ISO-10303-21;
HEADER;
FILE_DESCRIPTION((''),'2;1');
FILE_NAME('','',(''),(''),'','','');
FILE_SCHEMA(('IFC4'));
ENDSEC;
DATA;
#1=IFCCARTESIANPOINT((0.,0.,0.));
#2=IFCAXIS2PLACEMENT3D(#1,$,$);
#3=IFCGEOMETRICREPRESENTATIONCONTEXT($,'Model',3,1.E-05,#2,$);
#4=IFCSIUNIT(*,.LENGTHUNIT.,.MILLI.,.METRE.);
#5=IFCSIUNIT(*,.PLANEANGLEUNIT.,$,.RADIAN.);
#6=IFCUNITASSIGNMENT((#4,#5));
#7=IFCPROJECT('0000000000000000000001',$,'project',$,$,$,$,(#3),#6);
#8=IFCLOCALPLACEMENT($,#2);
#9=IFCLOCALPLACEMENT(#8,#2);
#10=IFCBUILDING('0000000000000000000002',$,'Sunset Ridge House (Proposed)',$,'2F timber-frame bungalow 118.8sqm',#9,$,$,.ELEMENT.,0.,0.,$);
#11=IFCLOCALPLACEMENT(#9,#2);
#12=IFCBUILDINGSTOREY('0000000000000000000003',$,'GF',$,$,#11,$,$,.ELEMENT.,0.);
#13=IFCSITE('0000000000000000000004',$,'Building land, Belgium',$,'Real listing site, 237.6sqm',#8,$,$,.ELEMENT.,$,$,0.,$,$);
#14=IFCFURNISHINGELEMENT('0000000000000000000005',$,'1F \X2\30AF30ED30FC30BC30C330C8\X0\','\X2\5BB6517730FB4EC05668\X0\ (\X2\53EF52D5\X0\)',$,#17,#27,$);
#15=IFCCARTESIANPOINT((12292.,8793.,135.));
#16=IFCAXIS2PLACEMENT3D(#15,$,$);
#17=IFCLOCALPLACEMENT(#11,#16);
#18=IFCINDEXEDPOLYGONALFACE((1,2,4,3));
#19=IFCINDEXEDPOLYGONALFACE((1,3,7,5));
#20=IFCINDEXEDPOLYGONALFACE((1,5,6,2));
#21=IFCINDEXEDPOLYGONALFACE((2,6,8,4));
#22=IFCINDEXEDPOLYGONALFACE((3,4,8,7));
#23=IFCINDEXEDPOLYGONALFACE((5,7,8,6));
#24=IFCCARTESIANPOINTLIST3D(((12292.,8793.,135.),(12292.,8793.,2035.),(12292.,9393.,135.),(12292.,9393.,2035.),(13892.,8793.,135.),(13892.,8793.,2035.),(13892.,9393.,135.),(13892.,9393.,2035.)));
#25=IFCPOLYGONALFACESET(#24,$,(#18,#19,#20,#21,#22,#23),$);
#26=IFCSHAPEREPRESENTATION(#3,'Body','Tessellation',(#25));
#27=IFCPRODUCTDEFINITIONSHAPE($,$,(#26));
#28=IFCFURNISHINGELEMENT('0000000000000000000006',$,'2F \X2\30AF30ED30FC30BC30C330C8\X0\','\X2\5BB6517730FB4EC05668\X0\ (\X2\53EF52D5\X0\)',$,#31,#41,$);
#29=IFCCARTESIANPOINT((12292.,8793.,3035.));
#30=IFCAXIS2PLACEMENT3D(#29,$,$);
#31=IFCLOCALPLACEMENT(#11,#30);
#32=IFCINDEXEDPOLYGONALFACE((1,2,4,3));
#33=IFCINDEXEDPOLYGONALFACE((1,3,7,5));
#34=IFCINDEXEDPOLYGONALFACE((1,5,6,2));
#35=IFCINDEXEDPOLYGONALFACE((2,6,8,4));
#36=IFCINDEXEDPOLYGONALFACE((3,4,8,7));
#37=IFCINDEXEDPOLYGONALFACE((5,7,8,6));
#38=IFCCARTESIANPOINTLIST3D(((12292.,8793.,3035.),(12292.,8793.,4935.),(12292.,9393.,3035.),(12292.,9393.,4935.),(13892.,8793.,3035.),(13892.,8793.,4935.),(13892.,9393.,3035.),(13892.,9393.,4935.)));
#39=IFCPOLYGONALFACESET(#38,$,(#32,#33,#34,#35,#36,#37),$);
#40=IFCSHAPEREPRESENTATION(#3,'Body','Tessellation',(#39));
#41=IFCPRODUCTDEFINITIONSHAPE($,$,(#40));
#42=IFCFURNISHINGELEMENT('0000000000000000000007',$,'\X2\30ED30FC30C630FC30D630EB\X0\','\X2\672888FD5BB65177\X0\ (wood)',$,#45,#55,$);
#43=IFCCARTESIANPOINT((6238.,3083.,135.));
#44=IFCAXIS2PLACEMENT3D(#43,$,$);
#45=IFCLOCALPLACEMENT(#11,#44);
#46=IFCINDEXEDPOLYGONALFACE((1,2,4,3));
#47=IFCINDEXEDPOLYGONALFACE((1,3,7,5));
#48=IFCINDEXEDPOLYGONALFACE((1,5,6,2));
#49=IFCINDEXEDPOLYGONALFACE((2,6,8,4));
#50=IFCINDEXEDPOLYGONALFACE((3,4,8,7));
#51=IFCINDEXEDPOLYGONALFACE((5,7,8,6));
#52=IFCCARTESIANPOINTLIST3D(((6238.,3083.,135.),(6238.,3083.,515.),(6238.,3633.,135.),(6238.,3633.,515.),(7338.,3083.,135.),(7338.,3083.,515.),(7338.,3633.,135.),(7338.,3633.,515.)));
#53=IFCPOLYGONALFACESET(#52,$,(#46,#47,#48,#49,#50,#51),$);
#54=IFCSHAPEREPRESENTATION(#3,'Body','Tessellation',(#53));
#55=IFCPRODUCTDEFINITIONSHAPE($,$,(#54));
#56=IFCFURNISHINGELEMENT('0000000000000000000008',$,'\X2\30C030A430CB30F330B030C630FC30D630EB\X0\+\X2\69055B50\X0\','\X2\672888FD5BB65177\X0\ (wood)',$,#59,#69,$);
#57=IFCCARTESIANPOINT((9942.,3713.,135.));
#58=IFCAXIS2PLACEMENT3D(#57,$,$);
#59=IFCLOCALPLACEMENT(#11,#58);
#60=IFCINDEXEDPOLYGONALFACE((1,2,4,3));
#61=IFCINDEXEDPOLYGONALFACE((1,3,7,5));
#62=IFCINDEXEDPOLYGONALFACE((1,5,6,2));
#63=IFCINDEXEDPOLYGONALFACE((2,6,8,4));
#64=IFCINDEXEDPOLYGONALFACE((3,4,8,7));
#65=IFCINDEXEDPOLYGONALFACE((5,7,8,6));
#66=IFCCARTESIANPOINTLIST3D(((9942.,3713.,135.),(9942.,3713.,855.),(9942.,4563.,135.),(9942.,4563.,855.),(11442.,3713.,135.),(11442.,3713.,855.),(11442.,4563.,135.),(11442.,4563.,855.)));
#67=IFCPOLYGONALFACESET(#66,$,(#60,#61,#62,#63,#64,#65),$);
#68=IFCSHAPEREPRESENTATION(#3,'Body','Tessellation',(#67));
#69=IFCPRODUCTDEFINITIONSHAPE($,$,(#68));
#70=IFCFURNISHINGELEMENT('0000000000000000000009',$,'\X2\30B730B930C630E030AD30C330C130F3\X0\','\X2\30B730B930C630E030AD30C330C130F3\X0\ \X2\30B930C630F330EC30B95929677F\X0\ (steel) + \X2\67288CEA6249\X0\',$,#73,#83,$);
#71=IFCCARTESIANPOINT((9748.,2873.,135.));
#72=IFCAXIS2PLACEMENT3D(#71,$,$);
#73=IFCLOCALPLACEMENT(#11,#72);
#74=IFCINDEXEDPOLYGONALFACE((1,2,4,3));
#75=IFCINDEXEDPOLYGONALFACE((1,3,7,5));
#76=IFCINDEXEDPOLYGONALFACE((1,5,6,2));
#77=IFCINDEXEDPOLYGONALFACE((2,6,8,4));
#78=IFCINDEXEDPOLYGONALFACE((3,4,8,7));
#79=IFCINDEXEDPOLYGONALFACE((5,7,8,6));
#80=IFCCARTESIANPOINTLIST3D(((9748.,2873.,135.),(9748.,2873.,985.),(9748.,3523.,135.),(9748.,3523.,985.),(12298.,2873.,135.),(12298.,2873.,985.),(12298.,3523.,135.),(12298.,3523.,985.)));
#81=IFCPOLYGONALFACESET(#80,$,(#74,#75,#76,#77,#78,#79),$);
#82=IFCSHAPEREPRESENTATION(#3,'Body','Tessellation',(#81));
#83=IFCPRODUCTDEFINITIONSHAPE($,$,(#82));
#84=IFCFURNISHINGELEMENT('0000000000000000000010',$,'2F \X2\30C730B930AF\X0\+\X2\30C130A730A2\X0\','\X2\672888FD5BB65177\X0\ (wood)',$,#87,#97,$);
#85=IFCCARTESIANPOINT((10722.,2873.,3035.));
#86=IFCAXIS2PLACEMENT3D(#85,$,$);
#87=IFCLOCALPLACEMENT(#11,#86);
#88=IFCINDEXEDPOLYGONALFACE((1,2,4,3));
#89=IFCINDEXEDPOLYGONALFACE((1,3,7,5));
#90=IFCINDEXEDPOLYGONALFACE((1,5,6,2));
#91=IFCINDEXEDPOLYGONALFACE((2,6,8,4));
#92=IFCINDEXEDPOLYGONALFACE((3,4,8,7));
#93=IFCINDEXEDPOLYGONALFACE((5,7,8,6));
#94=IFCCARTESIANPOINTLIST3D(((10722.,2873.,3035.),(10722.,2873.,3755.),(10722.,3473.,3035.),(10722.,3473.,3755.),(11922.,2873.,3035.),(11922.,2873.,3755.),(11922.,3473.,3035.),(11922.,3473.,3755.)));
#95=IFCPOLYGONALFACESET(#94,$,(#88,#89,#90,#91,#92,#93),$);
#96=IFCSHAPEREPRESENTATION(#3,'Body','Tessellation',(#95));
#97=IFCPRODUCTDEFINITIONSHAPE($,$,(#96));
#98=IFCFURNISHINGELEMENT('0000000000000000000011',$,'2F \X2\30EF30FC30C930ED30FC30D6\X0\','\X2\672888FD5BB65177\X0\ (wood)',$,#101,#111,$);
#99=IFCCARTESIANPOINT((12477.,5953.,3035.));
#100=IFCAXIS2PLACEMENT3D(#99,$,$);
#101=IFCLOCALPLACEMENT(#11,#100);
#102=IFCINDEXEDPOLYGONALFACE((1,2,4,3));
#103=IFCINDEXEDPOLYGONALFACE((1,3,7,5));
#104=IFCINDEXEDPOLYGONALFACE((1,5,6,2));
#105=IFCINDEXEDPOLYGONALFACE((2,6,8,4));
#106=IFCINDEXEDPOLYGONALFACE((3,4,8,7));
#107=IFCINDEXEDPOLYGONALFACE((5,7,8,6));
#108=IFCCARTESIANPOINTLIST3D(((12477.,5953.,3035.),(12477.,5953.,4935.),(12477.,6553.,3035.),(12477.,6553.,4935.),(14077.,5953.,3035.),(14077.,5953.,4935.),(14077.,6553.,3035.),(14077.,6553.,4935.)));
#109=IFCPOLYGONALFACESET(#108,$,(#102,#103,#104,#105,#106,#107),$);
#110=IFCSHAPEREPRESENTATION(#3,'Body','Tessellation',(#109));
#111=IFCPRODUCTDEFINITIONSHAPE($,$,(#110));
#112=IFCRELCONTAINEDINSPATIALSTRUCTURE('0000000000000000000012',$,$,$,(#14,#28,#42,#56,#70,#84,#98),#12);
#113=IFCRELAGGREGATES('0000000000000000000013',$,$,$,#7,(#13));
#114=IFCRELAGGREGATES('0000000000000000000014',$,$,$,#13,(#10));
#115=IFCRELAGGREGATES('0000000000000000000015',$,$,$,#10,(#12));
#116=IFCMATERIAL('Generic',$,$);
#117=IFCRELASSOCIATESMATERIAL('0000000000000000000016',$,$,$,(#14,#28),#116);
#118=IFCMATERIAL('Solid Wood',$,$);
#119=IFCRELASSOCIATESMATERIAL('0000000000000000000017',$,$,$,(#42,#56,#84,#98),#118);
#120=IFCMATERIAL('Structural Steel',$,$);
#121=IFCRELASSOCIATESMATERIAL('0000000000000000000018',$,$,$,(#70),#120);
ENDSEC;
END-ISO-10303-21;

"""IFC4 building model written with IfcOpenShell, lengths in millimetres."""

from ifc_helpers import new_model, si_unit, frame, frame_2d, origin, place, context, project, spatial, rectangle, extrude, material, element, save


model = new_model("IFC4")

# Units and contexts
model_context = context("Model", 3, precision=1e-05, world=origin())
ifc_project = project(units=[si_unit("LENGTHUNIT", "METRE", prefix="MILLI"), si_unit("PLANEANGLEUNIT", "RADIAN")], contexts=[model_context])

# Site, building, storey
site_placement = place(None, origin())
site = spatial("IfcSite", under=ifc_project, at=site_placement, Name="Building land, Belgium", ObjectType="Real listing site, 237.6sqm", CompositionType="ELEMENT", RefElevation=0.0)
building_placement = place(site_placement, origin())
building = spatial("IfcBuilding", under=site, at=building_placement, Name="Sunset Ridge House (Proposed)", ObjectType="2F timber-frame bungalow 118.8sqm", CompositionType="ELEMENT", ElevationOfRefHeight=0.0, ElevationOfTerrain=0.0)
storey_placement = place(building_placement, origin())
storey = spatial("IfcBuildingStorey", under=building, at=storey_placement, Name="GF", CompositionType="ELEMENT", Elevation=0.0)

# Shared definitions
ifc_material_1 = material(Name="Solid Wood")

# Shared definitions
ifc_material_2 = material(Name="Generic")

# Furnishing elements
furnishing_1_placement = place(storey_placement, frame((12292.0, 8793.0, 135.0)))
element("IfcFurnishingElement", 1, at=furnishing_1_placement, inside=storey, material=ifc_material_2, Name="1F クローゼット", Description="家具・什器 (可動)", context=model_context, shape_type="SweptSolid", body=[
    extrude(rectangle(XDim=1600.0, YDim=600.0, at=frame_2d((800.0, 300.0))), frame((12292.0, 8793.0, 135.0)), (0.0, 0.0, 1.0), 1900.0),
])
furnishing_2_placement = place(storey_placement, frame((12292.0, 8793.0, 3035.0)))
element("IfcFurnishingElement", 2, at=furnishing_2_placement, inside=storey, material=ifc_material_2, Name="2F クローゼット", Description="家具・什器 (可動)", context=model_context, shape_type="SweptSolid", body=[
    extrude(rectangle(XDim=1600.0, YDim=600.0, at=frame_2d((800.0, 300.0))), frame((12292.0, 8793.0, 3035.0)), (0.0, 0.0, 1.0), 1900.0),
])
furnishing_3_placement = place(storey_placement, frame((6238.0, 3083.0, 135.0)))
element("IfcFurnishingElement", 3, at=furnishing_3_placement, inside=storey, material=ifc_material_1, Name="ローテーブル", Description="木製家具 (wood)", context=model_context, shape_type="SweptSolid", body=[
    extrude(rectangle(XDim=1100.0, YDim=550.0, at=frame_2d((550.0, 275.0))), frame((6238.0, 3083.0, 135.0)), (0.0, 0.0, 1.0), 380.0),
])
furnishing_4_placement = place(storey_placement, frame((9942.0, 3713.0, 135.0)))
element("IfcFurnishingElement", 4, at=furnishing_4_placement, inside=storey, material=ifc_material_1, Name="ダイニングテーブル+椅子", Description="木製家具 (wood)", context=model_context, shape_type="SweptSolid", body=[
    extrude(rectangle(XDim=1500.0, YDim=850.0, at=frame_2d((750.0, 425.0))), frame((9942.0, 3713.0, 135.0)), (0.0, 0.0, 1.0), 720.0),
])
ifc_material_3 = material(Name="Structural Steel")
furnishing_5_placement = place(storey_placement, frame((9748.0, 2873.0, 135.0)))
element("IfcFurnishingElement", 5, at=furnishing_5_placement, inside=storey, material=ifc_material_3, Name="システムキッチン", Description="システムキッチン ステンレス天板 (steel) + 木質扉", context=model_context, shape_type="SweptSolid", body=[
    extrude(rectangle(XDim=2550.0, YDim=650.0, at=frame_2d((1275.0, 325.0))), frame((9748.0, 2873.0, 135.0)), (0.0, 0.0, 1.0), 850.0),
])
furnishing_6_placement = place(storey_placement, frame((10722.0, 2873.0, 3035.0)))
element("IfcFurnishingElement", 6, at=furnishing_6_placement, inside=storey, material=ifc_material_1, Name="2F デスク+チェア", Description="木製家具 (wood)", context=model_context, shape_type="SweptSolid", body=[
    extrude(rectangle(XDim=1200.0, YDim=600.0, at=frame_2d((600.0, 300.0))), frame((10722.0, 2873.0, 3035.0)), (0.0, 0.0, 1.0), 720.0),
])
furnishing_7_placement = place(storey_placement, frame((12477.0, 5953.0, 3035.0)))
element("IfcFurnishingElement", 7, at=furnishing_7_placement, inside=storey, material=ifc_material_1, Name="2F ワードローブ", Description="木製家具 (wood)", context=model_context, shape_type="SweptSolid", body=[
    extrude(rectangle(XDim=1600.0, YDim=600.0, at=frame_2d((800.0, 300.0))), frame((12477.0, 5953.0, 3035.0)), (0.0, 0.0, 1.0), 1900.0),
])

save(model, "model.ifc")
